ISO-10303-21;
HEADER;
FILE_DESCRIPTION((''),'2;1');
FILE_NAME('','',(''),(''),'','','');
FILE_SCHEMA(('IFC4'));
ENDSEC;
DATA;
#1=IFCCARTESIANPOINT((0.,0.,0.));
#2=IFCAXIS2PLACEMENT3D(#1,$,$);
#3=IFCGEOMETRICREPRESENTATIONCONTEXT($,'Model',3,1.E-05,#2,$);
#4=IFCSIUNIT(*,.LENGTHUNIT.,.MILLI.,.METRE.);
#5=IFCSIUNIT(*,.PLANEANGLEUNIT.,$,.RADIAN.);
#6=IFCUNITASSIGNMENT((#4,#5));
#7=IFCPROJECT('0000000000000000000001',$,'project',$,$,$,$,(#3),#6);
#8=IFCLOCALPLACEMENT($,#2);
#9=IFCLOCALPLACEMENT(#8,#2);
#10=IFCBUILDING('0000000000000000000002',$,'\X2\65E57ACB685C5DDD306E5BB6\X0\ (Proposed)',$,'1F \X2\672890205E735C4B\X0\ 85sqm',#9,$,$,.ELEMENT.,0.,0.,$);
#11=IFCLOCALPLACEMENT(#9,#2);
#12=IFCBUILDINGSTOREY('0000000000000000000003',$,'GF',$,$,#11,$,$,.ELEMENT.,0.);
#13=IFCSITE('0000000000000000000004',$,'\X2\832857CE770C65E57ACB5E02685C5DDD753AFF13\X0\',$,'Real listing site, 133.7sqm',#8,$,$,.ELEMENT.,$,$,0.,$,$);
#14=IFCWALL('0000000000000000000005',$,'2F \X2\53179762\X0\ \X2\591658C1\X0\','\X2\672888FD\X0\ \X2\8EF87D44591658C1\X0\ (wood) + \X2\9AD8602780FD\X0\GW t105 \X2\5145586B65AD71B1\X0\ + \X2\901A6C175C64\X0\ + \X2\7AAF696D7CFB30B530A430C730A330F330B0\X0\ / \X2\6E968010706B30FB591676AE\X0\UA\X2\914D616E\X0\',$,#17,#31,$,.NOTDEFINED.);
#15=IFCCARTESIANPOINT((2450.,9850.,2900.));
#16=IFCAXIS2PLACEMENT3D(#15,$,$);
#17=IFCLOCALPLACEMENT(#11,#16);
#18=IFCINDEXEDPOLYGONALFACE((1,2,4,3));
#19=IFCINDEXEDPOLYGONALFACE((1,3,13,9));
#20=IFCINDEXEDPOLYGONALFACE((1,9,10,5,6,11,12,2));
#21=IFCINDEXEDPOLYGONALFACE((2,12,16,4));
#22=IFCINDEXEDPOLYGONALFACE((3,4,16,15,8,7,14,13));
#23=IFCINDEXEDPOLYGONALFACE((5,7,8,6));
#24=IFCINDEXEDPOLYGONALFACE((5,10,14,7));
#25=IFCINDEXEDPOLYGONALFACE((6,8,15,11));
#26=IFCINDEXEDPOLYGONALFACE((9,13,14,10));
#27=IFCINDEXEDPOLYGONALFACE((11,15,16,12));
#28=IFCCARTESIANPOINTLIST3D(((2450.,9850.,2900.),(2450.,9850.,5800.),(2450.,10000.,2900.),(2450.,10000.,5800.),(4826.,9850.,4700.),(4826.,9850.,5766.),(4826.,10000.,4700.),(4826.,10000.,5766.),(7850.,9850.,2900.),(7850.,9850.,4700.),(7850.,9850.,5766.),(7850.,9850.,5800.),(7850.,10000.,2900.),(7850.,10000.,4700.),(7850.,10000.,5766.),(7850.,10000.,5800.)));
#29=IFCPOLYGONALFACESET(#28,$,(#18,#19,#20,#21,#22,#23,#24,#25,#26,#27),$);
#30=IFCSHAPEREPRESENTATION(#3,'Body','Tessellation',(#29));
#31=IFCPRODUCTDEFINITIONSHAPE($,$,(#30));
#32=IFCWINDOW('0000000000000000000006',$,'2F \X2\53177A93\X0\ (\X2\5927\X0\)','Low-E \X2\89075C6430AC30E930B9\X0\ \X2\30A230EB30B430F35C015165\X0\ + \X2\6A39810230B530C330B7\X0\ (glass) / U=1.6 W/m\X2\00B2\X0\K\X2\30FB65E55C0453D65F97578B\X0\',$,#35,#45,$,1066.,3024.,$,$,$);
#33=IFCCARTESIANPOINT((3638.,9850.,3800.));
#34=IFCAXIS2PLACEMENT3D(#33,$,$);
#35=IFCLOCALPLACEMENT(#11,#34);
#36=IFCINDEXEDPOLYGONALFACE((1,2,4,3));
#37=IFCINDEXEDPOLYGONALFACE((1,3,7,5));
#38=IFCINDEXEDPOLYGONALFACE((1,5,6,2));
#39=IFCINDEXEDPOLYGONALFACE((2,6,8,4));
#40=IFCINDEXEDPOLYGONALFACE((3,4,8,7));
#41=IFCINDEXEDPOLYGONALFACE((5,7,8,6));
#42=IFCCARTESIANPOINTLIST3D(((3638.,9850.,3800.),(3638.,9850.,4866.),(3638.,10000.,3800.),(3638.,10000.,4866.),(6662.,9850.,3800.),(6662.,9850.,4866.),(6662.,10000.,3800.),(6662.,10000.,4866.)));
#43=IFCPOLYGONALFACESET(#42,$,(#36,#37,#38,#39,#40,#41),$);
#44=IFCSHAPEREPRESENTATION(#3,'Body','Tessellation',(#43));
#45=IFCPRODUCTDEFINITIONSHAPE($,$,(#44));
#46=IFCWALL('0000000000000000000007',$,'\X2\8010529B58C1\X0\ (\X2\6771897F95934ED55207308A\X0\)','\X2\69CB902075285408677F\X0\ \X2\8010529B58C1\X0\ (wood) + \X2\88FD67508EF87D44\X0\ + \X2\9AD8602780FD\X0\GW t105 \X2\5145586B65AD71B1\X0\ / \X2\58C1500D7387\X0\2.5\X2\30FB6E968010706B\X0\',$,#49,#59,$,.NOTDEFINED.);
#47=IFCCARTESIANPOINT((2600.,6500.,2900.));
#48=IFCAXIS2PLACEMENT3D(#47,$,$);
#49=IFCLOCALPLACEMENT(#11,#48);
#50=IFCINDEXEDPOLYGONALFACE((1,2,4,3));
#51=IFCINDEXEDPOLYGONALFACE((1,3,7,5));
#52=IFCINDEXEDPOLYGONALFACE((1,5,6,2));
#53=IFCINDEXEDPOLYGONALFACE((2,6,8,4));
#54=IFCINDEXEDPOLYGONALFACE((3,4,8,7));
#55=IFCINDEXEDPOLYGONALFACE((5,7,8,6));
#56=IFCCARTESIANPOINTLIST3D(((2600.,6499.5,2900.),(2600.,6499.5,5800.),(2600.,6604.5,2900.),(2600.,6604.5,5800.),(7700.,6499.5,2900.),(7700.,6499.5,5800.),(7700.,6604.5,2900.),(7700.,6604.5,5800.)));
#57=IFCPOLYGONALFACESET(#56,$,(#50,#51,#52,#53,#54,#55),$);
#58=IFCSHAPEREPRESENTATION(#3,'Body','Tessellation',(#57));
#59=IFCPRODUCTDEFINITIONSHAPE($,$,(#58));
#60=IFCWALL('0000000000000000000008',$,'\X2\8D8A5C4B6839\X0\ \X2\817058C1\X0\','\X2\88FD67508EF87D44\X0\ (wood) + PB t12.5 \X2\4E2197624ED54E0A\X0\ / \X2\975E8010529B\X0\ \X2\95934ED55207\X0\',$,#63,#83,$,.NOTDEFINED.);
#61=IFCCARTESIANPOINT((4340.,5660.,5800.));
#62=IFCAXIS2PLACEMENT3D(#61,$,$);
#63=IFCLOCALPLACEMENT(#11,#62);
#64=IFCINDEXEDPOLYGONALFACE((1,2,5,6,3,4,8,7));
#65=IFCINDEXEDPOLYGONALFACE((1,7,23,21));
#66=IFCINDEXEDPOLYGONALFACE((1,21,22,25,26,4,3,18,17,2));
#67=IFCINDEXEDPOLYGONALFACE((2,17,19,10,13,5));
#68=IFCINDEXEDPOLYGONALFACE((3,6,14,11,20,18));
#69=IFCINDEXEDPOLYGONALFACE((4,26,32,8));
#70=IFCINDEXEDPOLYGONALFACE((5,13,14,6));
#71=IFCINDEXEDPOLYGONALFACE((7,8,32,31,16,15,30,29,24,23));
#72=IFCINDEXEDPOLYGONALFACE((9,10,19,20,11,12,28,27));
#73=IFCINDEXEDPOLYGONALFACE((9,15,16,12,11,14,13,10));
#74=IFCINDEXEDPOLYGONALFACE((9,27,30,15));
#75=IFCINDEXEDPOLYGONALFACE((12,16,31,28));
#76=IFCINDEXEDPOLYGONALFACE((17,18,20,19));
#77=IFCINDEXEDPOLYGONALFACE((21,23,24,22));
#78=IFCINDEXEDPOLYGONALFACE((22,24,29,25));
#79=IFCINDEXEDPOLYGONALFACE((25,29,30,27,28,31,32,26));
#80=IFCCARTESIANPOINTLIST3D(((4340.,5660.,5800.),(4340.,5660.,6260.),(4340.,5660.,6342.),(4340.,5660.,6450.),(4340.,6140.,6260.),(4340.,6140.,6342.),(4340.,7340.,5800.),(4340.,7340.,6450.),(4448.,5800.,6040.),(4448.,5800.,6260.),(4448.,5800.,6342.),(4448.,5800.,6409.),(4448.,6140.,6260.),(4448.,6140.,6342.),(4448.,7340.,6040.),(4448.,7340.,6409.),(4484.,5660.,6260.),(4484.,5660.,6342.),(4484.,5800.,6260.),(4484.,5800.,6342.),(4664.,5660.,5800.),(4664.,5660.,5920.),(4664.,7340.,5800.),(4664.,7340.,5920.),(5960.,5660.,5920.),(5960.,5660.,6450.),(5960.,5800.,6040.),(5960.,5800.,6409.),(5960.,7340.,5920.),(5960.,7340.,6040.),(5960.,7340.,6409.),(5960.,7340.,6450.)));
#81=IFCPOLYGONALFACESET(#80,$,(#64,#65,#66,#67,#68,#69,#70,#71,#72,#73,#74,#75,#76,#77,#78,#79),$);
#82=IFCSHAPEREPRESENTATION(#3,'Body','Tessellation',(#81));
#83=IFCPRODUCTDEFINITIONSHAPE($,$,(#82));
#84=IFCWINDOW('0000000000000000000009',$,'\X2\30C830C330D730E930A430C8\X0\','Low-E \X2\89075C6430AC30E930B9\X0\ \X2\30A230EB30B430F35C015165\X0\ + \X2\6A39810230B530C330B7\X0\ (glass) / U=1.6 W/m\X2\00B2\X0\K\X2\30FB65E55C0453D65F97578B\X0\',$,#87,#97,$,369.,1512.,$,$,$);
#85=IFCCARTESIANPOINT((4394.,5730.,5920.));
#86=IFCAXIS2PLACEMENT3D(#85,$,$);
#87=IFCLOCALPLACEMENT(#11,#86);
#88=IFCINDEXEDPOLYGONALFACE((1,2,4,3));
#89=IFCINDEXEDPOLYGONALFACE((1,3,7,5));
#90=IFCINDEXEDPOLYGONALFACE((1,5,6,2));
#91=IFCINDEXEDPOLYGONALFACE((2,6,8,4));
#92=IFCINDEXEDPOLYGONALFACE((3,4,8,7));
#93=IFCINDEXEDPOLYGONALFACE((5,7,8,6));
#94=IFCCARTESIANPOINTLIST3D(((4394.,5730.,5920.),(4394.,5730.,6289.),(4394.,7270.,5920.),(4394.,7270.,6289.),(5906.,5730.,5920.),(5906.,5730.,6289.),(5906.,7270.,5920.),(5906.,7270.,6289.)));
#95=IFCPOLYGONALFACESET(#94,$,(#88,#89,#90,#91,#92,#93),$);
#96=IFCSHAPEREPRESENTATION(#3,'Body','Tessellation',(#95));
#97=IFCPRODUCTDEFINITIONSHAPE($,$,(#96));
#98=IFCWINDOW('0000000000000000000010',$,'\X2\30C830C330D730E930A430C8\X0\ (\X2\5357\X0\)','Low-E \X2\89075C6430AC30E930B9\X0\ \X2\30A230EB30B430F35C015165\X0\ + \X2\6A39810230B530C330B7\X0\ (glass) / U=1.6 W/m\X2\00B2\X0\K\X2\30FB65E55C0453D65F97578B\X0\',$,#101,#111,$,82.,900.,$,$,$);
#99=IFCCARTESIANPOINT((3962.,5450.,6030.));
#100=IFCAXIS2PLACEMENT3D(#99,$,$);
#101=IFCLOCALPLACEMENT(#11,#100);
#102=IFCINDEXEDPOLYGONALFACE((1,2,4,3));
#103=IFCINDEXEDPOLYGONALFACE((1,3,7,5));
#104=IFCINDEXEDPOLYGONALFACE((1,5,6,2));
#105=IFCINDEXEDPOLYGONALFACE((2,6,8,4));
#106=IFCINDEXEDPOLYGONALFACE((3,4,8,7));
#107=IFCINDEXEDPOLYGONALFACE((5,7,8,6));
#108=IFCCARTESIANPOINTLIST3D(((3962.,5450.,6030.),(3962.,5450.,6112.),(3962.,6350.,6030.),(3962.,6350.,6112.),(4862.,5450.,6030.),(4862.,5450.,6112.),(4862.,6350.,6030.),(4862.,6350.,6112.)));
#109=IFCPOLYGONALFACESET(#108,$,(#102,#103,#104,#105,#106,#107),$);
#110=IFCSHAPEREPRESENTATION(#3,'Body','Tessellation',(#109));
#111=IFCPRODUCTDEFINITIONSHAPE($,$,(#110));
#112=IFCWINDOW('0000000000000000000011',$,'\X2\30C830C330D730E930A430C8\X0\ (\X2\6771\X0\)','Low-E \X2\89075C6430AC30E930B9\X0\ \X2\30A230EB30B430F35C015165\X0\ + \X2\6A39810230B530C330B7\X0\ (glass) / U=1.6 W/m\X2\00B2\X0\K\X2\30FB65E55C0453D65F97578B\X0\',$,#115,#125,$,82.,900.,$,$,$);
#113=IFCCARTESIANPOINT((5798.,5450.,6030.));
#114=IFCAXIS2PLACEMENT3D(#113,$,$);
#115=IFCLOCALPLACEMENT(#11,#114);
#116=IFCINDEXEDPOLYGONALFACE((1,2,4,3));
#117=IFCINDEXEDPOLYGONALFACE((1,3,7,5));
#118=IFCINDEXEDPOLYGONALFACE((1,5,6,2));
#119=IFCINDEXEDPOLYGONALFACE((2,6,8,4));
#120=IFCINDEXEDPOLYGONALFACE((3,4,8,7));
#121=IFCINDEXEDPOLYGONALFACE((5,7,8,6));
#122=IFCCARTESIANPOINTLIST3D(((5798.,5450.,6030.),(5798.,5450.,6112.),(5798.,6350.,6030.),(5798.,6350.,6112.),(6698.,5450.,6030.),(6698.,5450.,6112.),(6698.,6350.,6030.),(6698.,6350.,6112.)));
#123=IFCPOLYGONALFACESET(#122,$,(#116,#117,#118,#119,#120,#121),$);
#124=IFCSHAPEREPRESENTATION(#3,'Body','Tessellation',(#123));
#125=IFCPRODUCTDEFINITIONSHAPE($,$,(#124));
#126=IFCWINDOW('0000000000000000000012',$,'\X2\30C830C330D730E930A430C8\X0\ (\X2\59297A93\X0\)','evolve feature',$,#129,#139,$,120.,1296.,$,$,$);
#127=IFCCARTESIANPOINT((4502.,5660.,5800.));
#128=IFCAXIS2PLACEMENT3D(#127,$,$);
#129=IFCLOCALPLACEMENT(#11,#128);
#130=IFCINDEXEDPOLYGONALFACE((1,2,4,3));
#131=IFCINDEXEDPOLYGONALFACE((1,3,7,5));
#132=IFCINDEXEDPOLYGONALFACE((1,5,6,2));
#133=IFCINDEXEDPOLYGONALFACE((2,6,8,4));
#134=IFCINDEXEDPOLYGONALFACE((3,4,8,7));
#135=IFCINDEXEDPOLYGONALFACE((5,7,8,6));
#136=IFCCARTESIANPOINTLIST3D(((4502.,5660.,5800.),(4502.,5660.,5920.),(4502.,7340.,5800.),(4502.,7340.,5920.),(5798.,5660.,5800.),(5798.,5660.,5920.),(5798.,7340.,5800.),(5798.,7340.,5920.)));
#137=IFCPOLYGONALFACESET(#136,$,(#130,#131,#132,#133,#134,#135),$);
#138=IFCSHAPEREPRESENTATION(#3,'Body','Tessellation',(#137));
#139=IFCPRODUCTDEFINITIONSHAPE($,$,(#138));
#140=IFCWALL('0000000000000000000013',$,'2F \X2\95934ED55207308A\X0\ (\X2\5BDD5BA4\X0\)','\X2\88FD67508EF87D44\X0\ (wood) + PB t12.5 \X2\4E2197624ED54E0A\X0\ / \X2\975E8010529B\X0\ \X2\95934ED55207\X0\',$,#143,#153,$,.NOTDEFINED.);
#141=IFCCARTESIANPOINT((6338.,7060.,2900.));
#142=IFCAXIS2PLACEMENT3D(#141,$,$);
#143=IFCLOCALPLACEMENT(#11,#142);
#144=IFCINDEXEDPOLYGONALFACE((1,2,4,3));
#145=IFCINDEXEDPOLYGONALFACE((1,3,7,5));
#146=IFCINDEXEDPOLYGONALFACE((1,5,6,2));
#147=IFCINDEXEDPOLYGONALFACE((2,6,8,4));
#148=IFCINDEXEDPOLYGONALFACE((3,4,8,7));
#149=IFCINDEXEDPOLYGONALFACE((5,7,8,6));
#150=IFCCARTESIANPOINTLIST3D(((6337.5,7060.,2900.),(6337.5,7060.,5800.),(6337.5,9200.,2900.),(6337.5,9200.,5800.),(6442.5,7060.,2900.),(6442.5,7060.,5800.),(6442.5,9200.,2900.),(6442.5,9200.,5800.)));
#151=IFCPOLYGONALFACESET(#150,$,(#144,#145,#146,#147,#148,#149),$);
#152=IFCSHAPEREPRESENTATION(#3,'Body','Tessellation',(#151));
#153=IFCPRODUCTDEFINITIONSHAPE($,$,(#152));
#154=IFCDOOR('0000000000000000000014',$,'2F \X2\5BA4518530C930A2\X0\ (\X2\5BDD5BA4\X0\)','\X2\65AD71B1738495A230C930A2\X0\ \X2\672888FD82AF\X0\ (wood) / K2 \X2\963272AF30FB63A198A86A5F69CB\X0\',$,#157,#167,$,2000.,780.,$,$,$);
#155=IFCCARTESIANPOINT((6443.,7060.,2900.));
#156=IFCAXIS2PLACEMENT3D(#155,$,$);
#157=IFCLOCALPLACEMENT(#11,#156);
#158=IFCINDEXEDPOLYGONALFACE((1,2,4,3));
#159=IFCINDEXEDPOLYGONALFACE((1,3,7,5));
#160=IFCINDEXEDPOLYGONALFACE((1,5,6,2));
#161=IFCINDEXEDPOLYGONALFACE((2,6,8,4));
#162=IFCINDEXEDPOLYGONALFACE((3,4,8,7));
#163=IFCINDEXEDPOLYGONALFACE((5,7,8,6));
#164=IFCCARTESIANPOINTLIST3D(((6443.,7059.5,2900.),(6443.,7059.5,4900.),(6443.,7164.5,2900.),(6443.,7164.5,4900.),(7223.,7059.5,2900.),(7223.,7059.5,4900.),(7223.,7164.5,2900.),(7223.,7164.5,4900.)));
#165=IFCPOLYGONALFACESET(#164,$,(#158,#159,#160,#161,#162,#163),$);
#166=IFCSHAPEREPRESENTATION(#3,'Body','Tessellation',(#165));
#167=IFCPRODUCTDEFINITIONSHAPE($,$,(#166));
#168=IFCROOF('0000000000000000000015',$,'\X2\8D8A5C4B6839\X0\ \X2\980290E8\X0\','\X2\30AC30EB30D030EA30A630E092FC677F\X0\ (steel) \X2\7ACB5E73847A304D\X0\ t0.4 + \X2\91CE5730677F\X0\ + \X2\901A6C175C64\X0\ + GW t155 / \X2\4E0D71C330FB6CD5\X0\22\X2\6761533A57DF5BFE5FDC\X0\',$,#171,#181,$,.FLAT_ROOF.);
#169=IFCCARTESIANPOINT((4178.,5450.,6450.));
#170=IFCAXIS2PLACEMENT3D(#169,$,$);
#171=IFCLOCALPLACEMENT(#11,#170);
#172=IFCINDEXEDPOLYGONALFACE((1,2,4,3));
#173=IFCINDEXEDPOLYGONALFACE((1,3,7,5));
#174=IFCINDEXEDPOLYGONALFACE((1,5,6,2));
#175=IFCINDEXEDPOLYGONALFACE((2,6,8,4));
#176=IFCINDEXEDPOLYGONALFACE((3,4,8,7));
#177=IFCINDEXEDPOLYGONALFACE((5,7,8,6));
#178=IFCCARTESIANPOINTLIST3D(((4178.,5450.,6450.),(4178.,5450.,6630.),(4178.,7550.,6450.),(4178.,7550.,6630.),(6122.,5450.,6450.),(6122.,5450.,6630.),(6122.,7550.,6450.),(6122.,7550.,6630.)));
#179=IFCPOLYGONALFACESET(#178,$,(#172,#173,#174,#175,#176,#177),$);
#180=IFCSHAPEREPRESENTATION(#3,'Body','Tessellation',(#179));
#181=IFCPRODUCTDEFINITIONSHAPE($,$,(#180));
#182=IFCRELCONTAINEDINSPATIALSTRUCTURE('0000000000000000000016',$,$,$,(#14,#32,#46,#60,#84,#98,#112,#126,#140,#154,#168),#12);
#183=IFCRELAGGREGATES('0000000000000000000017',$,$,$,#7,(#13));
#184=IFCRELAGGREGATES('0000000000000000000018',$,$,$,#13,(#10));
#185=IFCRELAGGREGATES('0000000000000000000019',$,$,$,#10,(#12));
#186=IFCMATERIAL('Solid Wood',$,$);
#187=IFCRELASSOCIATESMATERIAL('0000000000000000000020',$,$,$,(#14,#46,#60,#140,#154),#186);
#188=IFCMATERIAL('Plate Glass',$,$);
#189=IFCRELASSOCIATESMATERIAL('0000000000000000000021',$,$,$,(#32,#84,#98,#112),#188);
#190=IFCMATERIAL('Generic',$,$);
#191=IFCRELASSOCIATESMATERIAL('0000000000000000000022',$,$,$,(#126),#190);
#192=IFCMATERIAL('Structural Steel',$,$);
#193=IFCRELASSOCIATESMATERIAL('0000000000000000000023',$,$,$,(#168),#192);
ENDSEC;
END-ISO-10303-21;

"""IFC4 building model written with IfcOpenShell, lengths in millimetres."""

from ifc_helpers import new_model, si_unit, frame, frame_2d, origin, place, context, project, spatial, rectangle, extrude, material, element, fill, save


model = new_model("IFC4")

# Units and contexts
model_context = context("Model", 3, precision=1e-05, world=origin())
ifc_project = project(units=[si_unit("LENGTHUNIT", "METRE", prefix="MILLI"), si_unit("PLANEANGLEUNIT", "RADIAN")], contexts=[model_context])

# Site, building, storey
site_placement = place(None, origin())
site = spatial("IfcSite", under=ifc_project, at=site_placement, Name="茨城県日立市桜川町３", ObjectType="Real listing site, 133.7sqm", CompositionType="ELEMENT", RefElevation=0.0)
building_placement = place(site_placement, origin())
building = spatial("IfcBuilding", under=site, at=building_placement, Name="日立桜川の家 (Proposed)", ObjectType="1F 木造平屋 85sqm", CompositionType="ELEMENT", ElevationOfRefHeight=0.0, ElevationOfTerrain=0.0)
storey_placement = place(building_placement, origin())
storey = spatial("IfcBuildingStorey", under=building, at=storey_placement, Name="GF", CompositionType="ELEMENT", Elevation=0.0)

# Wall, opening, window
ifc_material_1 = material(Name="Solid Wood")
wall_1_placement = place(storey_placement, frame((2450.0, 9850.0, 2900.0)))
wall_1 = element("IfcWall", 1, at=wall_1_placement, inside=storey, material=ifc_material_1, Name="2F 北面 外壁", Description="木製 軸組外壁 (wood) + 高性能GW t105 充填断熱 + 通気層 + 窯業系サイディング / 準耐火・外皮UA配慮", PredefinedType="NOTDEFINED", context=model_context, shape_type="SweptSolid", body=[
    extrude(rectangle(XDim=5400.0, YDim=150.0, at=frame_2d((2700.0, 75.0))), frame((2450.0, 9850.0, 2900.0)), (0.0, 0.0, 1.0), 2900.0),
])
opening_1_placement = place(storey_placement, frame((3638.0, 9850.0, 3800.0)))
opening_1 = element("IfcOpeningElement", 2, at=opening_1_placement, cuts=wall_1, PredefinedType="NOTDEFINED", context=model_context, shape_type="SweptSolid", body=[
    extrude(rectangle(XDim=3024.0, YDim=150.0, at=frame_2d((1512.0, 75.0))), frame((3638.0, 9850.0, 3800.0)), (0.0, 0.0, 1.0), 1066.0),
])
ifc_material_2 = material(Name="Plate Glass")
window_1_placement = place(storey_placement, frame((3638.0, 9850.0, 3800.0)))
window_1 = element("IfcWindow", 3, at=window_1_placement, inside=storey, material=ifc_material_2, Name="2F 北窓 (大)", Description="Low-E 複層ガラス アルゴン封入 + 樹脂サッシ (glass) / U=1.6 W/m²K・日射取得型", OverallHeight=1066.0, OverallWidth=3024.0, context=model_context, shape_type="SweptSolid", body=[
    extrude(rectangle(XDim=3024.0, YDim=150.0, at=frame_2d((1512.0, 75.0))), frame((3638.0, 9850.0, 3800.0)), (0.0, 0.0, 1.0), 1066.0),
])
fill(opening_1, window_1)

# Wall
wall_2_placement = place(storey_placement, frame((2600.0, 6500.0, 2900.0)))
element("IfcWall", 4, at=wall_2_placement, inside=storey, material=ifc_material_1, Name="耐力壁 (東西間仕切り)", Description="構造用合板 耐力壁 (wood) + 製材軸組 + 高性能GW t105 充填断熱 / 壁倍率2.5・準耐火", PredefinedType="NOTDEFINED", context=model_context, shape_type="SweptSolid", body=[
    extrude(rectangle(XDim=5100.0, YDim=105.0, at=frame_2d((2550.0, 52.0))), frame((2600.0, 6500.0, 2900.0)), (0.0, 0.0, 1.0), 2900.0),
])

# Wall, openings, windows
wall_3_placement = place(storey_placement, frame((4340.0, 5660.0, 5800.0)))
wall_3 = element("IfcWall", 5, at=wall_3_placement, inside=storey, material=ifc_material_1, Name="越屋根 腰壁", Description="製材軸組 (wood) + PB t12.5 両面仕上 / 非耐力 間仕切", PredefinedType="NOTDEFINED", context=model_context, shape_type="SweptSolid", body=[
    extrude(rectangle(XDim=1620.0, YDim=1680.0, at=frame_2d((810.0, 840.0))), frame((4340.0, 5660.0, 5800.0)), (0.0, 0.0, 1.0), 650.0),
])
opening_2_placement = place(storey_placement, frame((4394.0, 5730.0, 5920.0)))
opening_2 = element("IfcOpeningElement", 6, at=opening_2_placement, cuts=wall_3, PredefinedType="NOTDEFINED", context=model_context, shape_type="SweptSolid", body=[
    extrude(rectangle(XDim=1512.0, YDim=1540.0, at=frame_2d((756.0, 770.0))), frame((4394.0, 5730.0, 5920.0)), (0.0, 0.0, 1.0), 369.0),
])
opening_3_placement = place(storey_placement, frame((3962.0, 5450.0, 6030.0)))
opening_3 = element("IfcOpeningElement", 7, at=opening_3_placement, cuts=wall_3, PredefinedType="NOTDEFINED", context=model_context, shape_type="SweptSolid", body=[
    extrude(rectangle(XDim=900.0, YDim=900.0, at=frame_2d((450.0, 450.0))), frame((3962.0, 5450.0, 6030.0)), (0.0, 0.0, 1.0), 82.0),
])
opening_4_placement = place(storey_placement, frame((5798.0, 5450.0, 6030.0)))
opening_4 = element("IfcOpeningElement", 8, at=opening_4_placement, cuts=wall_3, PredefinedType="NOTDEFINED", context=model_context, shape_type="SweptSolid", body=[
    extrude(rectangle(XDim=900.0, YDim=900.0, at=frame_2d((450.0, 450.0))), frame((5798.0, 5450.0, 6030.0)), (0.0, 0.0, 1.0), 82.0),
])
opening_5_placement = place(storey_placement, frame((4502.0, 5660.0, 5800.0)))
opening_5 = element("IfcOpeningElement", 9, at=opening_5_placement, cuts=wall_3, PredefinedType="NOTDEFINED", context=model_context, shape_type="SweptSolid", body=[
    extrude(rectangle(XDim=1296.0, YDim=1680.0, at=frame_2d((648.0, 840.0))), frame((4502.0, 5660.0, 5800.0)), (0.0, 0.0, 1.0), 120.0),
])
window_2_placement = place(storey_placement, frame((4394.0, 5730.0, 5920.0)))
window_2 = element("IfcWindow", 10, at=window_2_placement, inside=storey, material=ifc_material_2, Name="トップライト", Description="Low-E 複層ガラス アルゴン封入 + 樹脂サッシ (glass) / U=1.6 W/m²K・日射取得型", OverallHeight=369.0, OverallWidth=1512.0, context=model_context, shape_type="SweptSolid", body=[
    extrude(rectangle(XDim=1512.0, YDim=1540.0, at=frame_2d((756.0, 770.0))), frame((4394.0, 5730.0, 5920.0)), (0.0, 0.0, 1.0), 369.0),
])
fill(opening_2, window_2)
window_3_placement = place(storey_placement, frame((3962.0, 5450.0, 6030.0)))
window_3 = element("IfcWindow", 11, at=window_3_placement, inside=storey, material=ifc_material_2, Name="トップライト (南)", Description="Low-E 複層ガラス アルゴン封入 + 樹脂サッシ (glass) / U=1.6 W/m²K・日射取得型", OverallHeight=82.0, OverallWidth=900.0, context=model_context, shape_type="SweptSolid", body=[
    extrude(rectangle(XDim=900.0, YDim=900.0, at=frame_2d((450.0, 450.0))), frame((3962.0, 5450.0, 6030.0)), (0.0, 0.0, 1.0), 82.0),
])
fill(opening_3, window_3)
window_4_placement = place(storey_placement, frame((5798.0, 5450.0, 6030.0)))
window_4 = element("IfcWindow", 12, at=window_4_placement, inside=storey, material=ifc_material_2, Name="トップライト (東)", Description="Low-E 複層ガラス アルゴン封入 + 樹脂サッシ (glass) / U=1.6 W/m²K・日射取得型", OverallHeight=82.0, OverallWidth=900.0, context=model_context, shape_type="SweptSolid", body=[
    extrude(rectangle(XDim=900.0, YDim=900.0, at=frame_2d((450.0, 450.0))), frame((5798.0, 5450.0, 6030.0)), (0.0, 0.0, 1.0), 82.0),
])
fill(opening_4, window_4)
ifc_material_3 = material(Name="Generic")
window_5_placement = place(storey_placement, frame((4502.0, 5660.0, 5800.0)))
window_5 = element("IfcWindow", 13, at=window_5_placement, inside=storey, material=ifc_material_3, Name="トップライト (天窓)", Description="evolve feature", OverallHeight=120.0, OverallWidth=1296.0, context=model_context, shape_type="SweptSolid", body=[
    extrude(rectangle(XDim=1296.0, YDim=1680.0, at=frame_2d((648.0, 840.0))), frame((4502.0, 5660.0, 5800.0)), (0.0, 0.0, 1.0), 120.0),
])
fill(opening_5, window_5)

# Wall
wall_4_placement = place(storey_placement, frame((6338.0, 7060.0, 2900.0)))
element("IfcWall", 14, at=wall_4_placement, inside=storey, material=ifc_material_1, Name="2F 間仕切り (寝室)", Description="製材軸組 (wood) + PB t12.5 両面仕上 / 非耐力 間仕切", PredefinedType="NOTDEFINED", context=model_context, shape_type="SweptSolid", body=[
    extrude(rectangle(XDim=105.0, YDim=2140.0, at=frame_2d((52.0, 1070.0))), frame((6338.0, 7060.0, 2900.0)), (0.0, 0.0, 1.0), 2900.0),
])

# Door
door_placement = place(storey_placement, frame((6443.0, 7060.0, 2900.0)))
element("IfcDoor", 15, at=door_placement, inside=storey, material=ifc_material_1, Name="2F 室内ドア (寝室)", Description="断熱玄関ドア 木製芯 (wood) / K2 防犯・採風機構", OverallHeight=2000.0, OverallWidth=780.0, context=model_context, shape_type="SweptSolid", body=[
    extrude(rectangle(XDim=780.0, YDim=105.0, at=frame_2d((390.0, 52.0))), frame((6443.0, 7060.0, 2900.0)), (0.0, 0.0, 1.0), 2000.0),
])

# Roof
ifc_material_4 = material(Name="Structural Steel")
roof_placement = place(storey_placement, frame((4178.0, 5450.0, 6450.0)))
element("IfcRoof", 16, at=roof_placement, inside=storey, material=ifc_material_4, Name="越屋根 頂部", Description="ガルバリウム鋼板 (steel) 立平葺き t0.4 + 野地板 + 通気層 + GW t155 / 不燃・法22条区域対応", PredefinedType="FLAT_ROOF", context=model_context, shape_type="SweptSolid", body=[
    extrude(rectangle(XDim=1944.0, YDim=2100.0, at=frame_2d((972.0, 1050.0))), frame((4178.0, 5450.0, 6450.0)), (0.0, 0.0, 1.0), 180.0),
])

save(model, "model.ifc")
